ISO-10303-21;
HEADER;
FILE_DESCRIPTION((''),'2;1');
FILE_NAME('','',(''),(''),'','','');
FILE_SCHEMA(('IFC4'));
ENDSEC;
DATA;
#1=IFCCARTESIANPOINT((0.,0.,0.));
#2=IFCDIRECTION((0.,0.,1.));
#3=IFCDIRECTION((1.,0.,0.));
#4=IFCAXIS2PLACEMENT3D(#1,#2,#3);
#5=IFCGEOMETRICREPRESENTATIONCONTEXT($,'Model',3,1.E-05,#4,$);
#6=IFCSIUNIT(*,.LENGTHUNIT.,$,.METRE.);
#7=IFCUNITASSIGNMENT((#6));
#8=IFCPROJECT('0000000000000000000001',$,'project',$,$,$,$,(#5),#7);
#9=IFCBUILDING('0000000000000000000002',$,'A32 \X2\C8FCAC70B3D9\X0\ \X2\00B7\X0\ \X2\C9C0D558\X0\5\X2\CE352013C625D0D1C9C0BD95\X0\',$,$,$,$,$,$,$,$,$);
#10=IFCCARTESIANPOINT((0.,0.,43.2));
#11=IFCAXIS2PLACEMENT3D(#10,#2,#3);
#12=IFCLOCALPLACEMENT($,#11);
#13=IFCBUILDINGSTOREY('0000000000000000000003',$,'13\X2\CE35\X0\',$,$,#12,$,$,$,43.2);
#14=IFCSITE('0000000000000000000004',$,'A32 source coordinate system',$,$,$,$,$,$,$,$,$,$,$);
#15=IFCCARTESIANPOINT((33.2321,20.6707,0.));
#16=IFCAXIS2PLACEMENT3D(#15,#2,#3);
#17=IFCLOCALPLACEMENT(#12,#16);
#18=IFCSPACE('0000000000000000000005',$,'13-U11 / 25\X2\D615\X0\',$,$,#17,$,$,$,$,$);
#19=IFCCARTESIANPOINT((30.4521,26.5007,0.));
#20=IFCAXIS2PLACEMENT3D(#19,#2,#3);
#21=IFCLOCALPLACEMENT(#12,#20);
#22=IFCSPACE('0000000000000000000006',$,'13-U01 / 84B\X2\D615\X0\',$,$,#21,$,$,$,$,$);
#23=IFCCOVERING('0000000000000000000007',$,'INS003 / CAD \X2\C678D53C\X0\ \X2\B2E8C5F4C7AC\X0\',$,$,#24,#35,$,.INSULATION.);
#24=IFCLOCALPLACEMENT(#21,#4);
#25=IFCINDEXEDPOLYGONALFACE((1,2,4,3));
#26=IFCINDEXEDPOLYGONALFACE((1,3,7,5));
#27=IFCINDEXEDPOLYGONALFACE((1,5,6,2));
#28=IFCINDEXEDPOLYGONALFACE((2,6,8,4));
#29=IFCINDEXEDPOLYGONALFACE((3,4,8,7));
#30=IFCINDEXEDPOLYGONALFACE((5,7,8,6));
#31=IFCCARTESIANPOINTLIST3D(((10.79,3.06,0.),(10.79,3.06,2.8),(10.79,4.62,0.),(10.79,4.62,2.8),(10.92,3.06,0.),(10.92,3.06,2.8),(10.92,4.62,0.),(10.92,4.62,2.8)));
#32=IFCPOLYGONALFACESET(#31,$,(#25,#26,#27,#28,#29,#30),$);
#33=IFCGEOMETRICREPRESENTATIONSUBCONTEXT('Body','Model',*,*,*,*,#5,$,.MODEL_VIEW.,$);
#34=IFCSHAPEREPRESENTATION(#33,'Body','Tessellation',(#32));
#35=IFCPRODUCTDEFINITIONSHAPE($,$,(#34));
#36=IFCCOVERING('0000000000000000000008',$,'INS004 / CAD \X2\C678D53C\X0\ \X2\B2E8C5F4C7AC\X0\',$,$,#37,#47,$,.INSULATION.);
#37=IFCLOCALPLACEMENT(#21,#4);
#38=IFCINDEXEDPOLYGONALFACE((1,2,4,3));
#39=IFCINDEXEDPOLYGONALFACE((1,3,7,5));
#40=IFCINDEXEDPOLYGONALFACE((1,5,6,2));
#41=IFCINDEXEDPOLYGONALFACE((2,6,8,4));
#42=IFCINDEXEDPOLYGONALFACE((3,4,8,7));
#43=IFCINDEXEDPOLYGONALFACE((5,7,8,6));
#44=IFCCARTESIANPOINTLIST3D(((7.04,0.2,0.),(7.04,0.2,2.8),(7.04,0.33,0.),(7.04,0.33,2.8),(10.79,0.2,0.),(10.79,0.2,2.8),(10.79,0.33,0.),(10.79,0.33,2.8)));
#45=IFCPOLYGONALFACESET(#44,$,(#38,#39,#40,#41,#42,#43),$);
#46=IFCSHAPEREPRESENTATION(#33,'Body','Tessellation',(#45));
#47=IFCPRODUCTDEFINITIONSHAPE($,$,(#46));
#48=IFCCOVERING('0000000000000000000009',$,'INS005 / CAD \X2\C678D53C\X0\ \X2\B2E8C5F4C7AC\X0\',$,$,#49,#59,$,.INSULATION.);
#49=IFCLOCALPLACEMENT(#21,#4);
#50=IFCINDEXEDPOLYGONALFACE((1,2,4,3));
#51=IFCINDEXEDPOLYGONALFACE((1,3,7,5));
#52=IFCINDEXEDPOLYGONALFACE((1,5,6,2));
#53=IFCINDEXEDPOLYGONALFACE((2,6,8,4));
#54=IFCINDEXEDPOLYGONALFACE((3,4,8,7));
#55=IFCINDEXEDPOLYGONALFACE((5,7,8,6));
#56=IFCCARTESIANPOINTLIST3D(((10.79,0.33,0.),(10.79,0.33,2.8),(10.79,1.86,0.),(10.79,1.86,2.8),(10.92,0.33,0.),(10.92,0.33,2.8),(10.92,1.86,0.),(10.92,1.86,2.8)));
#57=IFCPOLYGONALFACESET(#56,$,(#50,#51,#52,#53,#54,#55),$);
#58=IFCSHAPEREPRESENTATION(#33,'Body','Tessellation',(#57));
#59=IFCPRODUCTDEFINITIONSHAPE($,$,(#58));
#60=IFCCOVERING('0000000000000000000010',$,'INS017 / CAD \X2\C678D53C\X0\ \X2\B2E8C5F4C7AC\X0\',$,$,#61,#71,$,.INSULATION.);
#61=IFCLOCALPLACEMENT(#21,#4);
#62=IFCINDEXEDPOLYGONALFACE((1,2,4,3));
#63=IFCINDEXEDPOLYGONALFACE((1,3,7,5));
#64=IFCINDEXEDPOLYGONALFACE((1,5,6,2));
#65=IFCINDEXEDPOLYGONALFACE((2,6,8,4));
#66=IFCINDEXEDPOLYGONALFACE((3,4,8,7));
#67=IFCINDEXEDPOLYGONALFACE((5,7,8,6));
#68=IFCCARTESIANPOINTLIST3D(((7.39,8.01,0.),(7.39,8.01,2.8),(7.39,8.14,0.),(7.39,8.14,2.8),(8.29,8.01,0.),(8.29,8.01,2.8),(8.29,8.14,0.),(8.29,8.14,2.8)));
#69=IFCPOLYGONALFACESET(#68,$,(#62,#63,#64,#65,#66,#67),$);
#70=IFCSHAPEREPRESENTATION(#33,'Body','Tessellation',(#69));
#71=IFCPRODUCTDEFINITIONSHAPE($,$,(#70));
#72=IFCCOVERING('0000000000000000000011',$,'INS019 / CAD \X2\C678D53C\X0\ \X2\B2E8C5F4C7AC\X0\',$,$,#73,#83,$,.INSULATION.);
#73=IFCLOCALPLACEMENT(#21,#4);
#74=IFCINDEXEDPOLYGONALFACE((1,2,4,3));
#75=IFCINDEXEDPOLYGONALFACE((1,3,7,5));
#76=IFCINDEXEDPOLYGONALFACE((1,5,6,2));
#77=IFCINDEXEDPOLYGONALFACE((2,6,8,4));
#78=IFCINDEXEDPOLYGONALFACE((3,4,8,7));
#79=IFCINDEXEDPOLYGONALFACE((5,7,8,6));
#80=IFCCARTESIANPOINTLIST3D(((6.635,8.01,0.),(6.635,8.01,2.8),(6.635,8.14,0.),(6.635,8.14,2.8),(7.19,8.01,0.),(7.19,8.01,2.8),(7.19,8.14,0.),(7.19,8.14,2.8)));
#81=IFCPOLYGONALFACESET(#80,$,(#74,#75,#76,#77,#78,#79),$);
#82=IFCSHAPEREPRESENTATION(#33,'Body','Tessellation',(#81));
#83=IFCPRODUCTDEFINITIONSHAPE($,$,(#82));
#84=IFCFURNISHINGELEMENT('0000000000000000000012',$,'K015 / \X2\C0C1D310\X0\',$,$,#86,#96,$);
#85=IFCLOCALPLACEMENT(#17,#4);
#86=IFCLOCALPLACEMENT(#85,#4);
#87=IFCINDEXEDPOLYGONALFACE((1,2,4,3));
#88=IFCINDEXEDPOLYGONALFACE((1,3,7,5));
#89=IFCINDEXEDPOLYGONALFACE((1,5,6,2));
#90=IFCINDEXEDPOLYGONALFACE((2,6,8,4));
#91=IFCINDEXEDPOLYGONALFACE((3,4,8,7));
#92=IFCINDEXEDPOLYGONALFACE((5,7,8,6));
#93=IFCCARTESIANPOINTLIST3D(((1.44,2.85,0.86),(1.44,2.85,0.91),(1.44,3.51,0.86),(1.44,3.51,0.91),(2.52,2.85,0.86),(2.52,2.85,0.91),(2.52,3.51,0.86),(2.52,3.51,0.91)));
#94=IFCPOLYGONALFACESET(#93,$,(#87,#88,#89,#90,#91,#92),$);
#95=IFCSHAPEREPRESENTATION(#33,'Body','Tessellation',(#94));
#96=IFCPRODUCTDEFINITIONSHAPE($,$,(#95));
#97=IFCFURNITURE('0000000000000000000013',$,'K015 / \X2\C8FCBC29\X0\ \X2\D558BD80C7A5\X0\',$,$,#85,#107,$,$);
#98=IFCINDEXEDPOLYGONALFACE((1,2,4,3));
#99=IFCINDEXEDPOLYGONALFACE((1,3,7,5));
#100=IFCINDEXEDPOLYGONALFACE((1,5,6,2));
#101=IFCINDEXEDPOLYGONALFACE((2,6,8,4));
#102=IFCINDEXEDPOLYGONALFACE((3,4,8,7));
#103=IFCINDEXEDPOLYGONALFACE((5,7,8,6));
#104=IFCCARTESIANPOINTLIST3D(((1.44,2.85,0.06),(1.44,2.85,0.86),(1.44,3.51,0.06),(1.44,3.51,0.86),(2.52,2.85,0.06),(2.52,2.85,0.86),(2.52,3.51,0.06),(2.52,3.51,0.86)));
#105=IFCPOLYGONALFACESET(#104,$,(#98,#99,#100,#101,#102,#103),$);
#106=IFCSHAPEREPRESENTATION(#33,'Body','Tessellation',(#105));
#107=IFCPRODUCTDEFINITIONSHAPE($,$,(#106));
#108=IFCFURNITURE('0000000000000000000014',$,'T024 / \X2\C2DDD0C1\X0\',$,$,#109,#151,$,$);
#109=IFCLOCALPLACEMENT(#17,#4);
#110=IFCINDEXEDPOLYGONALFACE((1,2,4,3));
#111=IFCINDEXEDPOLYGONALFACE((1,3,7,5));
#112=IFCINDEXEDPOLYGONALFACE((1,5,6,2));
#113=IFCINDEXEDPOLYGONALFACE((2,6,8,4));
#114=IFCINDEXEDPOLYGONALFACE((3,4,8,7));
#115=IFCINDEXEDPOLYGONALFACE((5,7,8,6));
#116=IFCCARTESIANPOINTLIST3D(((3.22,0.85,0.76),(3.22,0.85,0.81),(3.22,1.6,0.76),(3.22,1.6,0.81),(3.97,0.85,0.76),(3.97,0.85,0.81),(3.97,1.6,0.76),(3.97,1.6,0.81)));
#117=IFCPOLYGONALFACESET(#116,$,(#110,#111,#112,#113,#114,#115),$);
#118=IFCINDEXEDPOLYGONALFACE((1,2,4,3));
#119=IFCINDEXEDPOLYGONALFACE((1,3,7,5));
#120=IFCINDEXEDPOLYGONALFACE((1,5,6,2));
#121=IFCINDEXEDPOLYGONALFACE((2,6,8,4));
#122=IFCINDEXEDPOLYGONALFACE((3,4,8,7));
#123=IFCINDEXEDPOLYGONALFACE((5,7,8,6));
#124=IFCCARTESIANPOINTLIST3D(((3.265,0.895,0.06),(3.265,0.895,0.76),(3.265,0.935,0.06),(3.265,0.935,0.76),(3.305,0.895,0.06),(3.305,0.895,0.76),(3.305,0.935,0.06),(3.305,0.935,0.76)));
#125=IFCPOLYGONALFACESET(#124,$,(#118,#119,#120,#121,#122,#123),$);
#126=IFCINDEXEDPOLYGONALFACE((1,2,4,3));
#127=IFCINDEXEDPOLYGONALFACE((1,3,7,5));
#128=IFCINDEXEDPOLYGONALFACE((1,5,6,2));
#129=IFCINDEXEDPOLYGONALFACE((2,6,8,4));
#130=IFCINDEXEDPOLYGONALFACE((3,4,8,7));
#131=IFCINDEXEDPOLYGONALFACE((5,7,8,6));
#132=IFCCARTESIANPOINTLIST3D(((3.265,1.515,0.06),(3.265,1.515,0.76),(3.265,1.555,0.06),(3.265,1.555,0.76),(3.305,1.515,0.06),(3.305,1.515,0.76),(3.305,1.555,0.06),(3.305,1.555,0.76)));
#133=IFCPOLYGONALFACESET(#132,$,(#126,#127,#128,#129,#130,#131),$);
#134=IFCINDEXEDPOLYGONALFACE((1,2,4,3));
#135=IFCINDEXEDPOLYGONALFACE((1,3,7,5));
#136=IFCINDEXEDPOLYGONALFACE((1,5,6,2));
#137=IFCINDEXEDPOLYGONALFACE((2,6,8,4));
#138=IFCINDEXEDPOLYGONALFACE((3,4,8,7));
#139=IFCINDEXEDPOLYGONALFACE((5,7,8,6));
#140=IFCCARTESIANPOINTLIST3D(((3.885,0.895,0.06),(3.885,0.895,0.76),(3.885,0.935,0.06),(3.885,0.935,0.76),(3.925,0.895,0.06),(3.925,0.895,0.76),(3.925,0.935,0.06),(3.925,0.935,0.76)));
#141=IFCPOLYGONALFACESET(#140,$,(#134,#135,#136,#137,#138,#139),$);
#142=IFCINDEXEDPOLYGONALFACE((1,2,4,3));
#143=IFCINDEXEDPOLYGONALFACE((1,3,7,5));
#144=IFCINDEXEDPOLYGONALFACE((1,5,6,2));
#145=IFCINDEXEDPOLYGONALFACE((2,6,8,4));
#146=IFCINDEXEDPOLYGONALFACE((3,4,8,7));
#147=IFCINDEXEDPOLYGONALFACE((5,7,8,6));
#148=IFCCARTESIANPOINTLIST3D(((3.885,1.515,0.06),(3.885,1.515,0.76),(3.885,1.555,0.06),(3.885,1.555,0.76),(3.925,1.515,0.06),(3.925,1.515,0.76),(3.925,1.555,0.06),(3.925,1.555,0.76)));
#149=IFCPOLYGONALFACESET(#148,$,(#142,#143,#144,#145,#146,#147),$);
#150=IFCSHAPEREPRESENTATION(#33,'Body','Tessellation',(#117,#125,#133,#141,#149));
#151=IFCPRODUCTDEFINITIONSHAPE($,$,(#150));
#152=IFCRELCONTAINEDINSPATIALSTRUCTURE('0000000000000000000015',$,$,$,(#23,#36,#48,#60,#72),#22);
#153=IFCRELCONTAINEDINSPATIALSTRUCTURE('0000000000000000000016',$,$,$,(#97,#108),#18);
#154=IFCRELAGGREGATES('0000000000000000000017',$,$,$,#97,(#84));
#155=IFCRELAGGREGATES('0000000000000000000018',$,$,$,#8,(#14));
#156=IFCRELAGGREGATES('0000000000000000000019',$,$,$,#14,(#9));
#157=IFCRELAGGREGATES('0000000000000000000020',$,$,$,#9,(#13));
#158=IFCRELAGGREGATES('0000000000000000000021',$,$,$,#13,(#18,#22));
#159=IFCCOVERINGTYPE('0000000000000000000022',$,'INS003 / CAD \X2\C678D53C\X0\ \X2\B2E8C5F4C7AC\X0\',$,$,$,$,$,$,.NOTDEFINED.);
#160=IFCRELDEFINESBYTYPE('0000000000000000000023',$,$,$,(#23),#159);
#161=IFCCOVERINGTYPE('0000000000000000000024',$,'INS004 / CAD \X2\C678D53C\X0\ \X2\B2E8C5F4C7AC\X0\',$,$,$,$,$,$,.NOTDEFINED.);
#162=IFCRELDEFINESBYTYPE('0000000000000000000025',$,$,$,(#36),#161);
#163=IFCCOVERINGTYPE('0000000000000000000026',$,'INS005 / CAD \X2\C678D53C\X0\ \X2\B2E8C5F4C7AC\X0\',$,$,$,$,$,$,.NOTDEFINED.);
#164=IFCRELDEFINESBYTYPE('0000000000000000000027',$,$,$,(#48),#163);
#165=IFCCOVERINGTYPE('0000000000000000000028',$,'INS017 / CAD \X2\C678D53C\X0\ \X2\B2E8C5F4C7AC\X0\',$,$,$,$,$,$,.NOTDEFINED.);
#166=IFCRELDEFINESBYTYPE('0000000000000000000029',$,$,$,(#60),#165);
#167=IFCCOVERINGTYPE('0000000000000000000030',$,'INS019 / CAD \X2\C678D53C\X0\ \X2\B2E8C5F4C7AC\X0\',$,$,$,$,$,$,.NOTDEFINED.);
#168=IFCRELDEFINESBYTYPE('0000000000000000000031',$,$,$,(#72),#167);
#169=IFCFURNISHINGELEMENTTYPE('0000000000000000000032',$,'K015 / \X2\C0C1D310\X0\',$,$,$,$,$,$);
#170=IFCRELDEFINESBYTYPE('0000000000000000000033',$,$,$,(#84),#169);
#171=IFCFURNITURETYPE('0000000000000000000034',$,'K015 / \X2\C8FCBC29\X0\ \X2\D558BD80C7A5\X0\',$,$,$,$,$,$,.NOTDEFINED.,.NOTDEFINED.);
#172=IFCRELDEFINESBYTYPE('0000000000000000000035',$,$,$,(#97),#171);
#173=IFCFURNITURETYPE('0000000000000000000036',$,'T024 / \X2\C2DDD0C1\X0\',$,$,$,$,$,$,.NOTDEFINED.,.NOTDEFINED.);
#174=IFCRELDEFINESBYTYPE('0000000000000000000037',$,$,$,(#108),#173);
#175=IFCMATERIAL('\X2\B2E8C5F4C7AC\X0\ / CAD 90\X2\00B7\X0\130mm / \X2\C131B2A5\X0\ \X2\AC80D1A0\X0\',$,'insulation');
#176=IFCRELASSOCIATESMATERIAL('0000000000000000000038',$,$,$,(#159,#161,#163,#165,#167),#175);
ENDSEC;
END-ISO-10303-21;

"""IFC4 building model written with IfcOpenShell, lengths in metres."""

from ifc_helpers import new_model, si_unit, frame, origin, origin_with_axes, place, context, subcontext, project, spatial, polyline, outline, extrude, source, transform, mapped, material, type_object, type_shapes, element, aggregate, save


model = new_model("IFC4")

# Units and contexts
model_context = context("Model", 3, precision=1e-05, world=origin_with_axes())
body_context = subcontext(model_context, "Body", "Model", "MODEL_VIEW")
ifc_project = project(units=[si_unit("LENGTHUNIT", "METRE")], contexts=[model_context])

# Site, building, storey, space
site = spatial("IfcSite", under=ifc_project, Name="A32 source coordinate system")
building = spatial("IfcBuilding", under=site, Name="A32 주거동 · 지하5층–옥탑지붕")
storey_placement = place(None, frame((0.0, 0.0, 43.2), z_axis=(0.0, 0.0, 1.0), x_axis=(1.0, 0.0, 0.0)))
storey = spatial("IfcBuildingStorey", under=building, at=storey_placement, Name="13층", Elevation=43.2)
space_1_placement = place(storey_placement, frame((33.2321, 20.6707, 0.0), z_axis=(0.0, 0.0, 1.0), x_axis=(1.0, 0.0, 0.0)))
space_1 = spatial("IfcSpace", under=storey, at=space_1_placement, Name="13-U11 / 25형")

# Shared definitions
space_2_placement = place(storey_placement, frame((30.4521, 26.5007, 0.0), z_axis=(0.0, 0.0, 1.0), x_axis=(1.0, 0.0, 0.0)))
space_2 = spatial("IfcSpace", under=storey, at=space_2_placement, Name="13-U01 / 84B형")

# Coverings
ifc_material = material(Name="단열재 / CAD 90·130mm / 성능 검토", Category="insulation")
covering_type_1 = type_object("IfcCoveringType", Name="INS003 / CAD 외피 단열재", PredefinedType="NOTDEFINED", material=ifc_material)
shared_shape_1 = source(origin(), body_context, "Body", "SweptSolid", [
    extrude(outline(polyline([(10.79, 3.06), (10.79, 4.62), (10.92, 4.62), (10.92, 3.06), (10.79, 3.06)])), origin(), (0.0, 0.0, 1.0), 2.8),
])
type_shapes(covering_type_1, [shared_shape_1])
covering_1_placement = place(space_2_placement, origin_with_axes())
element("IfcCovering", 1, at=covering_1_placement, inside=space_2, type_object=covering_type_1, Name="INS003 / CAD 외피 단열재", PredefinedType="INSULATION", context=body_context, shape_type="MappedRepresentation", body=[
    mapped(shared_shape_1, transform((0.0, 0.0, 0.0), scale=1.0)),
])
covering_type_2 = type_object("IfcCoveringType", Name="INS004 / CAD 외피 단열재", PredefinedType="NOTDEFINED", material=ifc_material)
shared_shape_2 = source(origin(), body_context, "Body", "SweptSolid", [
    extrude(outline(polyline([(7.04, 0.33), (10.79, 0.33), (10.79, 0.2), (7.04, 0.2), (7.04, 0.33)])), origin(), (0.0, 0.0, 1.0), 2.8),
])
type_shapes(covering_type_2, [shared_shape_2])
covering_2_placement = place(space_2_placement, origin_with_axes())
element("IfcCovering", 2, at=covering_2_placement, inside=space_2, type_object=covering_type_2, Name="INS004 / CAD 외피 단열재", PredefinedType="INSULATION", context=body_context, shape_type="MappedRepresentation", body=[
    mapped(shared_shape_2, transform((0.0, 0.0, 0.0), scale=1.0)),
])
covering_type_3 = type_object("IfcCoveringType", Name="INS005 / CAD 외피 단열재", PredefinedType="NOTDEFINED", material=ifc_material)
shared_shape_3 = source(origin(), body_context, "Body", "SweptSolid", [
    extrude(outline(polyline([(10.79, 0.33), (10.79, 1.86), (10.92, 1.86), (10.92, 0.33), (10.79, 0.33)])), origin(), (0.0, 0.0, 1.0), 2.8),
])
type_shapes(covering_type_3, [shared_shape_3])
covering_3_placement = place(space_2_placement, origin_with_axes())
element("IfcCovering", 3, at=covering_3_placement, inside=space_2, type_object=covering_type_3, Name="INS005 / CAD 외피 단열재", PredefinedType="INSULATION", context=body_context, shape_type="MappedRepresentation", body=[
    mapped(shared_shape_3, transform((0.0, 0.0, 0.0), scale=1.0)),
])
covering_type_4 = type_object("IfcCoveringType", Name="INS017 / CAD 외피 단열재", PredefinedType="NOTDEFINED", material=ifc_material)
shared_shape_4 = source(origin(), body_context, "Body", "SweptSolid", [
    extrude(outline(polyline([(8.29, 8.01), (7.39, 8.01), (7.39, 8.14), (8.29, 8.14), (8.29, 8.01)])), origin(), (0.0, 0.0, 1.0), 2.8),
])
type_shapes(covering_type_4, [shared_shape_4])
covering_4_placement = place(space_2_placement, origin_with_axes())
element("IfcCovering", 4, at=covering_4_placement, inside=space_2, type_object=covering_type_4, Name="INS017 / CAD 외피 단열재", PredefinedType="INSULATION", context=body_context, shape_type="MappedRepresentation", body=[
    mapped(shared_shape_4, transform((0.0, 0.0, 0.0), scale=1.0)),
])
covering_type_5 = type_object("IfcCoveringType", Name="INS019 / CAD 외피 단열재", PredefinedType="NOTDEFINED", material=ifc_material)
shared_shape_5 = source(origin(), body_context, "Body", "SweptSolid", [
    extrude(outline(polyline([(6.635, 8.01), (6.635, 8.14), (7.19, 8.14), (7.19, 8.01), (6.635, 8.01)])), origin(), (0.0, 0.0, 1.0), 2.8),
])
type_shapes(covering_type_5, [shared_shape_5])
covering_5_placement = place(space_2_placement, origin_with_axes())
element("IfcCovering", 5, at=covering_5_placement, inside=space_2, type_object=covering_type_5, Name="INS019 / CAD 외피 단열재", PredefinedType="INSULATION", context=body_context, shape_type="MappedRepresentation", body=[
    mapped(shared_shape_5, transform((0.0, 0.0, 0.0), scale=1.0)),
])

# Furnishing element
furnishing_element_type_1 = type_object("IfcFurnishingElementType", Name="K015 / 상판")
shared_shape_6 = source(origin(), body_context, "Body", "SweptSolid", [
    extrude(outline(polyline([(2.52, 2.85), (1.44, 2.85), (1.44, 3.51), (2.52, 3.51), (2.52, 2.85)])), frame((0.0, 0.0, 0.86)), (0.0, 0.0, 1.0), 0.05),
])
type_shapes(furnishing_element_type_1, [shared_shape_6])
furniture_1_placement = place(space_1_placement, origin_with_axes())
furnishing_1_placement = place(furniture_1_placement, origin_with_axes())
furnishing_1 = element("IfcFurnishingElement", 6, at=furnishing_1_placement, type_object=furnishing_element_type_1, Name="K015 / 상판", context=body_context, shape_type="MappedRepresentation", body=[
    mapped(shared_shape_6, transform((0.0, 0.0, 0.0), scale=1.0)),
])

# Furniture
furniture_type_1 = type_object("IfcFurnitureType", Name="K015 / 주방 하부장", AssemblyPlace="NOTDEFINED", PredefinedType="NOTDEFINED")
shared_shape_7 = source(origin(), body_context, "Body", "SweptSolid", [
    extrude(outline(polyline([(2.52, 3.51), (2.52, 2.85), (1.44, 2.85), (1.44, 3.51), (2.52, 3.51)])), frame((0.0, 0.0, 0.06)), (0.0, 0.0, 1.0), 0.8),
])
type_shapes(furniture_type_1, [shared_shape_7])
furniture_1 = element("IfcFurniture", 7, at=furniture_1_placement, inside=space_1, type_object=furniture_type_1, Name="K015 / 주방 하부장", context=body_context, shape_type="MappedRepresentation", body=[
    mapped(shared_shape_7, transform((0.0, 0.0, 0.0), scale=1.0)),
])
aggregate(furniture_1, [furnishing_1])
furniture_type_2 = type_object("IfcFurnitureType", Name="T024 / 식탁", AssemblyPlace="NOTDEFINED", PredefinedType="NOTDEFINED")
shared_shape_8 = source(origin(), body_context, "Body", "SweptSolid", [
    extrude(outline(polyline([(3.22, 0.85), (3.22, 1.6), (3.97, 1.6), (3.97, 0.85), (3.22, 0.85)])), frame((0.0, 0.0, 0.76)), (0.0, 0.0, 1.0), 0.05),
    extrude(outline(polyline([(3.265, 0.895), (3.265, 0.935), (3.305, 0.935), (3.305, 0.895), (3.265, 0.895)])), frame((0.0, 0.0, 0.06)), (0.0, 0.0, 1.0), 0.7),
    extrude(outline(polyline([(3.265, 1.515), (3.265, 1.555), (3.305, 1.555), (3.305, 1.515), (3.265, 1.515)])), frame((0.0, 0.0, 0.06)), (0.0, 0.0, 1.0), 0.7),
    extrude(outline(polyline([(3.885, 0.895), (3.885, 0.935), (3.925, 0.935), (3.925, 0.895), (3.885, 0.895)])), frame((0.0, 0.0, 0.06)), (0.0, 0.0, 1.0), 0.7),
    extrude(outline(polyline([(3.885, 1.515), (3.885, 1.555), (3.925, 1.555), (3.925, 1.515), (3.885, 1.515)])), frame((0.0, 0.0, 0.06)), (0.0, 0.0, 1.0), 0.7),
])
type_shapes(furniture_type_2, [shared_shape_8])
furniture_2_placement = place(space_1_placement, origin_with_axes())
element("IfcFurniture", 8, at=furniture_2_placement, inside=space_1, type_object=furniture_type_2, Name="T024 / 식탁", context=body_context, shape_type="MappedRepresentation", body=[
    mapped(shared_shape_8, transform((0.0, 0.0, 0.0), scale=1.0)),
])

save(model, "model.ifc")
